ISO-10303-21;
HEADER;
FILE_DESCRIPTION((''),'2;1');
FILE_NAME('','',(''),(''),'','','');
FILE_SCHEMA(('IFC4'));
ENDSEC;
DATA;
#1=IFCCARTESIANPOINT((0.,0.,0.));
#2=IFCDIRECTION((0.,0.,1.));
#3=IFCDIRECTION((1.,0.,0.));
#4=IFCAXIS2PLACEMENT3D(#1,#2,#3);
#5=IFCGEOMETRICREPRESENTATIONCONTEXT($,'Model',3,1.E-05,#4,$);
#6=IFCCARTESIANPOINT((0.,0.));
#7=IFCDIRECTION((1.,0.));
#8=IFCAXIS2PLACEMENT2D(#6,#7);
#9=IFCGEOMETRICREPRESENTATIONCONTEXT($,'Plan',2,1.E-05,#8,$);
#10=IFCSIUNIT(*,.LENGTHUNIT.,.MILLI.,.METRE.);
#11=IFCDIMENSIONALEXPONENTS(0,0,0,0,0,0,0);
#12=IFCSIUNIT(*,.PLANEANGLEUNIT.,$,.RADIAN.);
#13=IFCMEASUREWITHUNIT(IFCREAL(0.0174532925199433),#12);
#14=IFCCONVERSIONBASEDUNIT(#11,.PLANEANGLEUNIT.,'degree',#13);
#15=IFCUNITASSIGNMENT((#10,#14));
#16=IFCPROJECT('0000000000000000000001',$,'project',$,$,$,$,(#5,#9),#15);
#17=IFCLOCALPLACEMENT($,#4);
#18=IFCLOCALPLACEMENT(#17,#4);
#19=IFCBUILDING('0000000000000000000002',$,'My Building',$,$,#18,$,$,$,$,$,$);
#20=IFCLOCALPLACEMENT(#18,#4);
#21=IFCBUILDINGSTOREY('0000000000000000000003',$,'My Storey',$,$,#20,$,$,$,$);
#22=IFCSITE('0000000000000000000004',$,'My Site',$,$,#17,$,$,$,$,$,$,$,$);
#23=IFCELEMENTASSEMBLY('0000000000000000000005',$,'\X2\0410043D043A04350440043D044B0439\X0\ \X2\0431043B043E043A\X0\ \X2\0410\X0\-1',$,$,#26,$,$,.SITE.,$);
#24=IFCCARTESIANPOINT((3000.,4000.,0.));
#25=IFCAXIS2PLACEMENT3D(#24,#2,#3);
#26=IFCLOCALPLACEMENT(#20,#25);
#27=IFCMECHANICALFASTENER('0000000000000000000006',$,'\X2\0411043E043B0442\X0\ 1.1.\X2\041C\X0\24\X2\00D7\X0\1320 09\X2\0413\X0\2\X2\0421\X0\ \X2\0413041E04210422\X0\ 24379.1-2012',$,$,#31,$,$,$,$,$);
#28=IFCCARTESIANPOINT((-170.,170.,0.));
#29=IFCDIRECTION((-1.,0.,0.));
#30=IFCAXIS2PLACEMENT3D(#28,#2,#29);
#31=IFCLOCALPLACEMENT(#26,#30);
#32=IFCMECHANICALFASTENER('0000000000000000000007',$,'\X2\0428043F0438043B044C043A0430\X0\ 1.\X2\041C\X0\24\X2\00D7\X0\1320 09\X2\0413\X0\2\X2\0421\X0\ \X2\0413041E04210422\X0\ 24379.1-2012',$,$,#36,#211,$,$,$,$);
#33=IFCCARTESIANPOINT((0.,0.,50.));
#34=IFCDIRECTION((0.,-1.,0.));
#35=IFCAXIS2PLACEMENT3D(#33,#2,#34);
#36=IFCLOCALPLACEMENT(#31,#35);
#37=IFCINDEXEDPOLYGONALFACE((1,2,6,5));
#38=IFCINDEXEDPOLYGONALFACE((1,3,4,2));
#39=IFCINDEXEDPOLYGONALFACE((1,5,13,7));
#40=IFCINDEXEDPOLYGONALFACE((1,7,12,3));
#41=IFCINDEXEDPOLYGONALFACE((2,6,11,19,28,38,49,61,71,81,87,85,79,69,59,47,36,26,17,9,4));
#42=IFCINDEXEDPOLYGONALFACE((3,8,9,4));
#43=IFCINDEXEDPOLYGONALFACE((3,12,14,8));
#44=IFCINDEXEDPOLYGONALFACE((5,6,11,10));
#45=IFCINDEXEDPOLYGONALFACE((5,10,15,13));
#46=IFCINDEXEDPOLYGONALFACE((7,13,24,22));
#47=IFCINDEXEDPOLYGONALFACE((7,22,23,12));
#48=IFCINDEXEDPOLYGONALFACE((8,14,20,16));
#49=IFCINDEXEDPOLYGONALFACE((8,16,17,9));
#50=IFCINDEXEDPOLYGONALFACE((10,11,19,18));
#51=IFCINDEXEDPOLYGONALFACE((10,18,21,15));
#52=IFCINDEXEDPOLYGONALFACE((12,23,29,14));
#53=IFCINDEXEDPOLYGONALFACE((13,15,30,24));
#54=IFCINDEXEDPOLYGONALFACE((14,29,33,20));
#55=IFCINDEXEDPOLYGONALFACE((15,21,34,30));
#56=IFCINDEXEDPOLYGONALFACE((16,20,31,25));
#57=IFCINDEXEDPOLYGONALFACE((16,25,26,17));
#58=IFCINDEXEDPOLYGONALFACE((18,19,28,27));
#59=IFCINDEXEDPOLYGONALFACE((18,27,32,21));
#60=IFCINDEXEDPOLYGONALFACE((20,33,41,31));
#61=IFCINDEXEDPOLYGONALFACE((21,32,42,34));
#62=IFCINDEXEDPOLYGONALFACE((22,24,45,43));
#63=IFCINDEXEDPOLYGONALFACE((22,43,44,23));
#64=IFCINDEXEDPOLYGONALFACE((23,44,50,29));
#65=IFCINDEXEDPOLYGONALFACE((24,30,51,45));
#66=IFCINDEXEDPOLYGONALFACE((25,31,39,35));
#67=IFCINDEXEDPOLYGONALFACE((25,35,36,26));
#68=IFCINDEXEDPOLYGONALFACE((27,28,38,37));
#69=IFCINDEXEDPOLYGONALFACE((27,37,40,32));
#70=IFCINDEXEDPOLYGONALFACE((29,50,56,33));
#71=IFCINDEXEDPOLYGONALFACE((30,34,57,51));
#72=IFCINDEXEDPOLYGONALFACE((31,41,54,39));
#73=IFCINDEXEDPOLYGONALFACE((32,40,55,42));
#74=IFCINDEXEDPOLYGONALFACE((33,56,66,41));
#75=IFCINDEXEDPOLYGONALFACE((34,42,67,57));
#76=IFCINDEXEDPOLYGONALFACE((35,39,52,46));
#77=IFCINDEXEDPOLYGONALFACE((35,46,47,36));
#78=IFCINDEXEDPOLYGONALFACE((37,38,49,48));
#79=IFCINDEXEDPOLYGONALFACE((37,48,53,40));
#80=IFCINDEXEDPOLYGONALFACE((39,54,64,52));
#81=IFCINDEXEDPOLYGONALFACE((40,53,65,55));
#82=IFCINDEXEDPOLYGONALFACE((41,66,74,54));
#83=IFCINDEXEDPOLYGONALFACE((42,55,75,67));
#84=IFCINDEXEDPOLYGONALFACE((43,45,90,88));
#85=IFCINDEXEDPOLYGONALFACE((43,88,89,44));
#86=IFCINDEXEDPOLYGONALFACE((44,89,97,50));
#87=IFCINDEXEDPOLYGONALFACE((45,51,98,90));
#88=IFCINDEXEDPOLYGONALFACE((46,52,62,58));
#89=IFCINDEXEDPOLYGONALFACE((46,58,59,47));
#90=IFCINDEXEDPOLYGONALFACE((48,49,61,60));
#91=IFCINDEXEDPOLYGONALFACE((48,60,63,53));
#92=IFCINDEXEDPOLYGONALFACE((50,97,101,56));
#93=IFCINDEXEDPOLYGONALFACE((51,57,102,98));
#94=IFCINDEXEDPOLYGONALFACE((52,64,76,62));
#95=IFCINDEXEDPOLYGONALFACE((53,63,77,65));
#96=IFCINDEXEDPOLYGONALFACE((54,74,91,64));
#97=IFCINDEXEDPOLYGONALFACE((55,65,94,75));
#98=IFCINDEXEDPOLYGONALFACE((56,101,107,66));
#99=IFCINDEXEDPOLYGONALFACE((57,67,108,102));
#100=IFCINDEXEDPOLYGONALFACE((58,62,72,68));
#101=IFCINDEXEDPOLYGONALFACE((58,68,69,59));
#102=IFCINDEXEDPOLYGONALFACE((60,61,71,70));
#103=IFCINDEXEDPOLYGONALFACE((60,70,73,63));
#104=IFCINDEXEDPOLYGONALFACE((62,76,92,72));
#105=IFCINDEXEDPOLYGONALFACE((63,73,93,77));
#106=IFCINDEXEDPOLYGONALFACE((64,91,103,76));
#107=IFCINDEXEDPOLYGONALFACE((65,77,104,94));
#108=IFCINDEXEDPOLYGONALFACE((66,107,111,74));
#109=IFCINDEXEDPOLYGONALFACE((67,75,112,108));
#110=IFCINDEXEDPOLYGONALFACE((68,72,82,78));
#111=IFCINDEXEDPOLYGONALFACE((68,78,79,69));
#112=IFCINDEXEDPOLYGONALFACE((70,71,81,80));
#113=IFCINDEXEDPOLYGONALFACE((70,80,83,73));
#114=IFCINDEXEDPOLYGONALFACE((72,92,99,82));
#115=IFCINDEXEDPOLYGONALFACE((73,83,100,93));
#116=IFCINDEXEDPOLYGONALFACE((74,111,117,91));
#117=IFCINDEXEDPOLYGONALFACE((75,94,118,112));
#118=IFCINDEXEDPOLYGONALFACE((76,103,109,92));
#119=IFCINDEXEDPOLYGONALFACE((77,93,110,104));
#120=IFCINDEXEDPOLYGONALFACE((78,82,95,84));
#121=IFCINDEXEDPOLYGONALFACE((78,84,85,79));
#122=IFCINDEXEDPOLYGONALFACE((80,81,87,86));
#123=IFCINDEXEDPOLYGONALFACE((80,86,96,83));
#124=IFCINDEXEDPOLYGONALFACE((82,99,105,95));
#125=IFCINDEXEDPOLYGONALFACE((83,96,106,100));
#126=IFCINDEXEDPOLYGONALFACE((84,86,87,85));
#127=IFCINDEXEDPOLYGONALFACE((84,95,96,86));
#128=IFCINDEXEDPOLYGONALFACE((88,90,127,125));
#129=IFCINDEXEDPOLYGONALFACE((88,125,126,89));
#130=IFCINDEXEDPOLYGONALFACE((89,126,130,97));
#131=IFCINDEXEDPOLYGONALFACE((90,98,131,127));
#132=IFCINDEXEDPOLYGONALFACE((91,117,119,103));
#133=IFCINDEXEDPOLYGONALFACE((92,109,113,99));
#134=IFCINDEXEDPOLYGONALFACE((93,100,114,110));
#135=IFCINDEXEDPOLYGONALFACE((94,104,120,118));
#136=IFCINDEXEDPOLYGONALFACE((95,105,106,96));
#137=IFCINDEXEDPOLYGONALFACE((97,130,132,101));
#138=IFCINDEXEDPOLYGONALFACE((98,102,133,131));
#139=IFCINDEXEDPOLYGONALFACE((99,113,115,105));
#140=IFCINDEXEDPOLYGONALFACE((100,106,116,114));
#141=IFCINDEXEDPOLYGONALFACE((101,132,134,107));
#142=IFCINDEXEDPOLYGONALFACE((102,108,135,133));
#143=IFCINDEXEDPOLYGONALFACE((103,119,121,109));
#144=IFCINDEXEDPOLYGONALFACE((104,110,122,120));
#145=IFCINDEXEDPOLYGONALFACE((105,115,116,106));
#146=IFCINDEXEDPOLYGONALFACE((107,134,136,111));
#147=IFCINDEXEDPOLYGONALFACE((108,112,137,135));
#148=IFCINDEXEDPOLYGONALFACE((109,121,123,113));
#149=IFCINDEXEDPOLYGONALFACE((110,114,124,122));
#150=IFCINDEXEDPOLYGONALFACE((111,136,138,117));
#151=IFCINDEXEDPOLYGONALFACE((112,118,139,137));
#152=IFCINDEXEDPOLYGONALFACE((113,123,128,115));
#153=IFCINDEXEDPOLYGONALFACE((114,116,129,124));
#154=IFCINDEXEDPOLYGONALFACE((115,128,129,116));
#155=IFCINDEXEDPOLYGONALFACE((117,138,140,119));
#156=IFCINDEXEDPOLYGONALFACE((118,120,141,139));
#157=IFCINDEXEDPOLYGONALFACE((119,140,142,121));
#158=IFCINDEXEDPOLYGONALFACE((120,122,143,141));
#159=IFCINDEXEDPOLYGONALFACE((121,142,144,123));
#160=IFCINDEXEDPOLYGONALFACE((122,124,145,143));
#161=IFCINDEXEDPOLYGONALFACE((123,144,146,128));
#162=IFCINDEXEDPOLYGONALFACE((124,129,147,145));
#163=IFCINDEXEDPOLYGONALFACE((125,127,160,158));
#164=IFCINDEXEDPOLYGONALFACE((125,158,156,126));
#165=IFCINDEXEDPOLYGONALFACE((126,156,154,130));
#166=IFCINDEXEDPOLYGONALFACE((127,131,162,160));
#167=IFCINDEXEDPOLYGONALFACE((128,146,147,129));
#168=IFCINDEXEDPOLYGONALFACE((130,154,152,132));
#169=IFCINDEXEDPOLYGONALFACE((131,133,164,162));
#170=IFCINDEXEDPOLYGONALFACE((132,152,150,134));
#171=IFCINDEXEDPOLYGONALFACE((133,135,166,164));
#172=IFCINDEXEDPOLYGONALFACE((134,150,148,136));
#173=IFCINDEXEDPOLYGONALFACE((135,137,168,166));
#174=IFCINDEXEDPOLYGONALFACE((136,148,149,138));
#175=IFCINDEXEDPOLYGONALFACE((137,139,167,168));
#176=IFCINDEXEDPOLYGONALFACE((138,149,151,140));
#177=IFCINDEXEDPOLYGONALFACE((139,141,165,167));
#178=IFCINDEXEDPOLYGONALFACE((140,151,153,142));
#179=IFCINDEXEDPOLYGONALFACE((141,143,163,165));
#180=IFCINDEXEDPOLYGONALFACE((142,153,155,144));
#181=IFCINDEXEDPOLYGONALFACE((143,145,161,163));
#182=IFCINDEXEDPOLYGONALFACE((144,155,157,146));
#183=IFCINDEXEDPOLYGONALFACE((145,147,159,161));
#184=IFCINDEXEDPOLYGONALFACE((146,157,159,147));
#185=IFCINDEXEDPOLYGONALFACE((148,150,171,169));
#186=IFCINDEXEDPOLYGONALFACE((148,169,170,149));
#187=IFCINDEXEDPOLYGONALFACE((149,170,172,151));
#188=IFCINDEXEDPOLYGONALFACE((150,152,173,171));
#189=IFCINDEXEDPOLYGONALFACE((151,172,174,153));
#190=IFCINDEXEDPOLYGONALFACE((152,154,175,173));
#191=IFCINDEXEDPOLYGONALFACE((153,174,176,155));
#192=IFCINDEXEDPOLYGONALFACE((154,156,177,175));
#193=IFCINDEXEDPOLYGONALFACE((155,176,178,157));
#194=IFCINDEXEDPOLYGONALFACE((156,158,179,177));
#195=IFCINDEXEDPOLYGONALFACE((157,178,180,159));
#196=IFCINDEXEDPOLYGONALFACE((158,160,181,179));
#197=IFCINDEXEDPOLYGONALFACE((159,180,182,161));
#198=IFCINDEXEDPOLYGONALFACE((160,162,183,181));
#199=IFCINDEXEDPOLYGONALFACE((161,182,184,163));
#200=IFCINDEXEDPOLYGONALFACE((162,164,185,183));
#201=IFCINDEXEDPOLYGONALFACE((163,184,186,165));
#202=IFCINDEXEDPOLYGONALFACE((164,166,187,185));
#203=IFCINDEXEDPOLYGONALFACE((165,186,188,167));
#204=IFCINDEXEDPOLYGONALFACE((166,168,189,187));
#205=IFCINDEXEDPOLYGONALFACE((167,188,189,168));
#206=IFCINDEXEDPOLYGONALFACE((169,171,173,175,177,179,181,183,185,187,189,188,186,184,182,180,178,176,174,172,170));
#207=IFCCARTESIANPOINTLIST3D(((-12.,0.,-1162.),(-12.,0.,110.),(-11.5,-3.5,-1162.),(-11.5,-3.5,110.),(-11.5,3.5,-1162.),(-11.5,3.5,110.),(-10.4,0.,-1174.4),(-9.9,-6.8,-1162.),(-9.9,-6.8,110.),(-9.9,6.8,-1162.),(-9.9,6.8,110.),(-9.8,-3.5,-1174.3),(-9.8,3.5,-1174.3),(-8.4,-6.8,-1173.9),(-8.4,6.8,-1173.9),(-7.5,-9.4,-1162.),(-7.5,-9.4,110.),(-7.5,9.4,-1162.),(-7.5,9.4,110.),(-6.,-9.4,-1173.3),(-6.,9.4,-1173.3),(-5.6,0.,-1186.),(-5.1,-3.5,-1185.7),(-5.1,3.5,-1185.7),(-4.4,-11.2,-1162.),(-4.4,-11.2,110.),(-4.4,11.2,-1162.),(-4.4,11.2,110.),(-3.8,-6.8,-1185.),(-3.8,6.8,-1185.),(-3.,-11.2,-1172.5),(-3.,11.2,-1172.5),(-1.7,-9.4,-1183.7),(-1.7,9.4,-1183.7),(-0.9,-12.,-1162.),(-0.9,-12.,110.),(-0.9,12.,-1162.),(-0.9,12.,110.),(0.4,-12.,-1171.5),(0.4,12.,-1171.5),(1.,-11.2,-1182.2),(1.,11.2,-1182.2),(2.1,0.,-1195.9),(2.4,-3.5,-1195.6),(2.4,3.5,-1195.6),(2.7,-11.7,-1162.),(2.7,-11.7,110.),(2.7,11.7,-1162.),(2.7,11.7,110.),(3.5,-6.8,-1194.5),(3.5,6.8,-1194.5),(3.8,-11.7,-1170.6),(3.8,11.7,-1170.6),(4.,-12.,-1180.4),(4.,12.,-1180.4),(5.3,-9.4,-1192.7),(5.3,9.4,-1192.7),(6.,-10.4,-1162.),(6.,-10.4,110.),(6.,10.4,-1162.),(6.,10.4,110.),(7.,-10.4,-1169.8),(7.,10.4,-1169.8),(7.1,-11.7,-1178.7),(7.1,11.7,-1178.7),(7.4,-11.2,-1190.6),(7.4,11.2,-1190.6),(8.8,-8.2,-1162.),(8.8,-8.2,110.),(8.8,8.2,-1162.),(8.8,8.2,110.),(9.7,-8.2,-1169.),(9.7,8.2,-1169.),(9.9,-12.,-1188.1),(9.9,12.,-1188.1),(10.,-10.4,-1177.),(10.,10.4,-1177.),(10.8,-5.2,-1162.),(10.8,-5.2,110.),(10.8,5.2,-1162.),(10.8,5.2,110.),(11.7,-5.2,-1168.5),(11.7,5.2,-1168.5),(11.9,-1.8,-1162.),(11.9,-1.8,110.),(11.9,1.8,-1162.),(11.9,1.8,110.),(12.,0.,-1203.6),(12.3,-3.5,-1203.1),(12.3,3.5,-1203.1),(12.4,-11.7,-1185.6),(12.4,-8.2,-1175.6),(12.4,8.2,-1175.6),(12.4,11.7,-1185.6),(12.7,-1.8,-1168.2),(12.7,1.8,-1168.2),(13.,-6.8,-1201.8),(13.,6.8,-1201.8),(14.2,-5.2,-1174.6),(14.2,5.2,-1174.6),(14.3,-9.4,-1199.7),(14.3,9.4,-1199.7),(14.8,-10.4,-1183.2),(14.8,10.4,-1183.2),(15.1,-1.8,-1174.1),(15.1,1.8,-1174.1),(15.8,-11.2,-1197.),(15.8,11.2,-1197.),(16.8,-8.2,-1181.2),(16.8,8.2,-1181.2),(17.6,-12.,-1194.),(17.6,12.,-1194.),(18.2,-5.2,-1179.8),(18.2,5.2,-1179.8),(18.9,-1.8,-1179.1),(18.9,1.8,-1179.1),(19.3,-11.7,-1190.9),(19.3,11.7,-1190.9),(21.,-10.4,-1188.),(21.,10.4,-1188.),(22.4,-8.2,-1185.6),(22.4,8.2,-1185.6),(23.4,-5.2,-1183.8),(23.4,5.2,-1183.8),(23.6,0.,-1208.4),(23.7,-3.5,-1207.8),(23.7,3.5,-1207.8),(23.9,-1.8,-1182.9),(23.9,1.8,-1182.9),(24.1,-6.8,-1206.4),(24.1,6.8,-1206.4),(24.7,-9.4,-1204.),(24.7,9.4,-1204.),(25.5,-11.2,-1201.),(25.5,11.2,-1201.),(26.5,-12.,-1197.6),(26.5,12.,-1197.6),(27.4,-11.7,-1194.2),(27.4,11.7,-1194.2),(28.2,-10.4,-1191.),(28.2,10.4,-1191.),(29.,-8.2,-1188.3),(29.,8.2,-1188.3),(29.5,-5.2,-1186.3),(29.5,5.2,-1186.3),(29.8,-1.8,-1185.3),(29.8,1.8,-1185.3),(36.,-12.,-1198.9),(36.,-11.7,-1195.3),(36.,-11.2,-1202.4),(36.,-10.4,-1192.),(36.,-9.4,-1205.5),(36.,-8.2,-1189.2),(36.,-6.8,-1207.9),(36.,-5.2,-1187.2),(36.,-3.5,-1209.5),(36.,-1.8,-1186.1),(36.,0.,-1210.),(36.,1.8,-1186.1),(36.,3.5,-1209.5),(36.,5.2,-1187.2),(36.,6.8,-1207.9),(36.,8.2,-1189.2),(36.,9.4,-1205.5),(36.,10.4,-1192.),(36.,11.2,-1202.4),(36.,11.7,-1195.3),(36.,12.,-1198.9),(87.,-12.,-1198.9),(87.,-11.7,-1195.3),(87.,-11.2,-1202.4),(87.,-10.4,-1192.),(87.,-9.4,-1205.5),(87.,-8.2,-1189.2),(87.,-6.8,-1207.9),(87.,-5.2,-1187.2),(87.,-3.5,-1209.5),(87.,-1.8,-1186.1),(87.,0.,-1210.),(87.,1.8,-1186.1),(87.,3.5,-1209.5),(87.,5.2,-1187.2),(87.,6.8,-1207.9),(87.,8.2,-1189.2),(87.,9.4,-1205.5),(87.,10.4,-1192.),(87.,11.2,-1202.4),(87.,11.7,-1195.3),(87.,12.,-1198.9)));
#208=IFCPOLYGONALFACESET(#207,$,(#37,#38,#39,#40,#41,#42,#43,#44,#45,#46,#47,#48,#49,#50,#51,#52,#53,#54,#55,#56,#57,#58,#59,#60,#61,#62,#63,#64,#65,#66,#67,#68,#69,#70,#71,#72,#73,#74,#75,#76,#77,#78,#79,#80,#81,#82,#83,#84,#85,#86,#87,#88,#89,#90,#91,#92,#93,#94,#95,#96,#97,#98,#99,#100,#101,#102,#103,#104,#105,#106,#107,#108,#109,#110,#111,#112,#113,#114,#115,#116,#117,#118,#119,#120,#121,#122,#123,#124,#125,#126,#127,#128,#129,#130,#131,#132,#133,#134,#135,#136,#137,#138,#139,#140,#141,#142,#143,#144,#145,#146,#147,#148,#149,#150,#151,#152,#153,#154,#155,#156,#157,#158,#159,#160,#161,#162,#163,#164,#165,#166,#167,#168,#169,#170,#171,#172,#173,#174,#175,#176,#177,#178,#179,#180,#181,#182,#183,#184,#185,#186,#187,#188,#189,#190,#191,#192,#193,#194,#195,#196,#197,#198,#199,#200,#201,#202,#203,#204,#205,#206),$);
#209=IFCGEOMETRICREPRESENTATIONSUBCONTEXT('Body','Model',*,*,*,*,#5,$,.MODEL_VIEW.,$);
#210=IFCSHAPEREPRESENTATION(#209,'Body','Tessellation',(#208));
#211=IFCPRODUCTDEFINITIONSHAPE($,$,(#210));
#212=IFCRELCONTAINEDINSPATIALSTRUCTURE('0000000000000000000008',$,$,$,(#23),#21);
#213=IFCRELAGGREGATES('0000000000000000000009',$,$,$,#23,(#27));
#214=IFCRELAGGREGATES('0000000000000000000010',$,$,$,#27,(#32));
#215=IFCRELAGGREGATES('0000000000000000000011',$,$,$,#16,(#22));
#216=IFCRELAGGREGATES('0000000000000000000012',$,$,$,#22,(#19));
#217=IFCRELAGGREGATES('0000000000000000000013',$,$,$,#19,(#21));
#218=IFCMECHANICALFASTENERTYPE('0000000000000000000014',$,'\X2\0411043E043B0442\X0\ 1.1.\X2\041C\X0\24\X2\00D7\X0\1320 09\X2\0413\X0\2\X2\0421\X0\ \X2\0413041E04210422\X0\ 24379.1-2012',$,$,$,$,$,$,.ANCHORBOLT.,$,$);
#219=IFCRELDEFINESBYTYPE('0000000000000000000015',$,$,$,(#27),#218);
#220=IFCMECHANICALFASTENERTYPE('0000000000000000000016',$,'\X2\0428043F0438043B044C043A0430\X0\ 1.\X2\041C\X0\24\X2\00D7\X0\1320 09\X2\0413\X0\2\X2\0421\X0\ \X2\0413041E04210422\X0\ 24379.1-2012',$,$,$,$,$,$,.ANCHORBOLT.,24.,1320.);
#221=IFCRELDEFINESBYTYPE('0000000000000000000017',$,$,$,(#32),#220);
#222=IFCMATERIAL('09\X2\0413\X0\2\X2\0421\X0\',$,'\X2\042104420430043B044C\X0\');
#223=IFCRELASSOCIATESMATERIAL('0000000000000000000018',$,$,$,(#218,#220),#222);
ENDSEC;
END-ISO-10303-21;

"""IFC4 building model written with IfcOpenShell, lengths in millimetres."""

from ifc_helpers import new_model, entity, si_unit, converted_unit, frame, origin_with_axes, origin_2d_with_axis, place, context, subcontext, project, spatial, source, transform, mapped, material, type_object, type_shapes, element, aggregate, save


model = new_model("IFC4")

# Units and contexts
model_context = context("Model", 3, precision=1e-05, world=origin_with_axes())
plan_context = context("Plan", 2, precision=1e-05, world=origin_2d_with_axis())
body_context = subcontext(model_context, "Body", "Model", "MODEL_VIEW")
ifc_project = project(units=[si_unit("LENGTHUNIT", "METRE", prefix="MILLI"), converted_unit("PLANEANGLEUNIT", "degree", entity("IfcReal", 0.0174532925199433), si_unit("PLANEANGLEUNIT", "RADIAN"), dimensions=[0, 0, 0, 0, 0, 0, 0])], contexts=[model_context, plan_context])

# Site, building, storey
site_placement = place(None, origin_with_axes())
site = spatial("IfcSite", under=ifc_project, at=site_placement, Name="My Site")
building_placement = place(site_placement, origin_with_axes())
building = spatial("IfcBuilding", under=site, at=building_placement, Name="My Building")
storey_placement = place(building_placement, origin_with_axes())
storey = spatial("IfcBuildingStorey", under=building, at=storey_placement, Name="My Storey")

# Element assembly, mechanical fasteners
ifc_material_1 = material(Name="09Г2С", Category="Сталь")
mechanical_fastener_type_1 = type_object("IfcMechanicalFastenerType", Name="Болт 1.1.М24×1320 09Г2С ГОСТ 24379.1-2012", PredefinedType="ANCHORBOLT", material=ifc_material_1)
mechanical_fastener_type_2 = type_object("IfcMechanicalFastenerType", Name="Шпилька 1.М24×1320 09Г2С ГОСТ 24379.1-2012", NominalDiameter=24.0, NominalLength=1320.0, PredefinedType="ANCHORBOLT", material=ifc_material_1)
shared_shape_1 = source(frame((0.0, 0.0, 110.0), z_axis=(0.0, 0.0, 1.0), x_axis=(1.0, 0.0, 0.0)), body_context, "Body", "AdvancedSweptSolid", [
    entity("IfcSweptDiskSolid", entity("IfcIndexedPolyCurve", entity("IfcCartesianPointList3D", [[0.0, 0.0, 0.0], [0.0, 0.0, -1272.0], [10.5, 0.0, -1297.5], [36.0, 0.0, -1308.0], [87.0, 0.0, -1308.0]]), [entity("IfcLineIndex", [1, 2]), entity("IfcArcIndex", [2, 3, 4]), entity("IfcLineIndex", [4, 5])]), 12.0),
])
type_shapes(mechanical_fastener_type_2, [shared_shape_1])
assembly_1_placement = place(storey_placement, frame((3000.0, 4000.0, 0.0), z_axis=(0.0, 0.0, 1.0), x_axis=(1.0, 0.0, 0.0)))
assembly_1 = element("IfcElementAssembly", 1, at=assembly_1_placement, inside=storey, Name="Анкерный блок А-1", AssemblyPlace="SITE")
mechanical_fastener_1_placement = place(assembly_1_placement, frame((-170.0, 170.0, 0.0), z_axis=(0.0, 0.0, 1.0), x_axis=(-1.0, 0.0, 0.0)))
mechanical_fastener_1 = element("IfcMechanicalFastener", 2, at=mechanical_fastener_1_placement, type_object=mechanical_fastener_type_1, Name="Болт 1.1.М24×1320 09Г2С ГОСТ 24379.1-2012")
mechanical_fastener_2_placement = place(mechanical_fastener_1_placement, frame((0.0, 0.0, 50.0), z_axis=(0.0, 0.0, 1.0), x_axis=(0.0, -1.0, 0.0)))
mechanical_fastener_2 = element("IfcMechanicalFastener", 3, at=mechanical_fastener_2_placement, type_object=mechanical_fastener_type_2, Name="Шпилька 1.М24×1320 09Г2С ГОСТ 24379.1-2012", context=body_context, shape_type="MappedRepresentation", body=[
    mapped(shared_shape_1, transform((0.0, 0.0, 0.0), x_axis=(1.0, 0.0, 0.0), y_axis=(0.0, 1.0, 0.0), z_axis=(0.0, 0.0, 1.0), scale=1.0)),
])
aggregate(assembly_1, [mechanical_fastener_1])

aggregate(mechanical_fastener_1, [mechanical_fastener_2])

save(model, "model.ifc")
